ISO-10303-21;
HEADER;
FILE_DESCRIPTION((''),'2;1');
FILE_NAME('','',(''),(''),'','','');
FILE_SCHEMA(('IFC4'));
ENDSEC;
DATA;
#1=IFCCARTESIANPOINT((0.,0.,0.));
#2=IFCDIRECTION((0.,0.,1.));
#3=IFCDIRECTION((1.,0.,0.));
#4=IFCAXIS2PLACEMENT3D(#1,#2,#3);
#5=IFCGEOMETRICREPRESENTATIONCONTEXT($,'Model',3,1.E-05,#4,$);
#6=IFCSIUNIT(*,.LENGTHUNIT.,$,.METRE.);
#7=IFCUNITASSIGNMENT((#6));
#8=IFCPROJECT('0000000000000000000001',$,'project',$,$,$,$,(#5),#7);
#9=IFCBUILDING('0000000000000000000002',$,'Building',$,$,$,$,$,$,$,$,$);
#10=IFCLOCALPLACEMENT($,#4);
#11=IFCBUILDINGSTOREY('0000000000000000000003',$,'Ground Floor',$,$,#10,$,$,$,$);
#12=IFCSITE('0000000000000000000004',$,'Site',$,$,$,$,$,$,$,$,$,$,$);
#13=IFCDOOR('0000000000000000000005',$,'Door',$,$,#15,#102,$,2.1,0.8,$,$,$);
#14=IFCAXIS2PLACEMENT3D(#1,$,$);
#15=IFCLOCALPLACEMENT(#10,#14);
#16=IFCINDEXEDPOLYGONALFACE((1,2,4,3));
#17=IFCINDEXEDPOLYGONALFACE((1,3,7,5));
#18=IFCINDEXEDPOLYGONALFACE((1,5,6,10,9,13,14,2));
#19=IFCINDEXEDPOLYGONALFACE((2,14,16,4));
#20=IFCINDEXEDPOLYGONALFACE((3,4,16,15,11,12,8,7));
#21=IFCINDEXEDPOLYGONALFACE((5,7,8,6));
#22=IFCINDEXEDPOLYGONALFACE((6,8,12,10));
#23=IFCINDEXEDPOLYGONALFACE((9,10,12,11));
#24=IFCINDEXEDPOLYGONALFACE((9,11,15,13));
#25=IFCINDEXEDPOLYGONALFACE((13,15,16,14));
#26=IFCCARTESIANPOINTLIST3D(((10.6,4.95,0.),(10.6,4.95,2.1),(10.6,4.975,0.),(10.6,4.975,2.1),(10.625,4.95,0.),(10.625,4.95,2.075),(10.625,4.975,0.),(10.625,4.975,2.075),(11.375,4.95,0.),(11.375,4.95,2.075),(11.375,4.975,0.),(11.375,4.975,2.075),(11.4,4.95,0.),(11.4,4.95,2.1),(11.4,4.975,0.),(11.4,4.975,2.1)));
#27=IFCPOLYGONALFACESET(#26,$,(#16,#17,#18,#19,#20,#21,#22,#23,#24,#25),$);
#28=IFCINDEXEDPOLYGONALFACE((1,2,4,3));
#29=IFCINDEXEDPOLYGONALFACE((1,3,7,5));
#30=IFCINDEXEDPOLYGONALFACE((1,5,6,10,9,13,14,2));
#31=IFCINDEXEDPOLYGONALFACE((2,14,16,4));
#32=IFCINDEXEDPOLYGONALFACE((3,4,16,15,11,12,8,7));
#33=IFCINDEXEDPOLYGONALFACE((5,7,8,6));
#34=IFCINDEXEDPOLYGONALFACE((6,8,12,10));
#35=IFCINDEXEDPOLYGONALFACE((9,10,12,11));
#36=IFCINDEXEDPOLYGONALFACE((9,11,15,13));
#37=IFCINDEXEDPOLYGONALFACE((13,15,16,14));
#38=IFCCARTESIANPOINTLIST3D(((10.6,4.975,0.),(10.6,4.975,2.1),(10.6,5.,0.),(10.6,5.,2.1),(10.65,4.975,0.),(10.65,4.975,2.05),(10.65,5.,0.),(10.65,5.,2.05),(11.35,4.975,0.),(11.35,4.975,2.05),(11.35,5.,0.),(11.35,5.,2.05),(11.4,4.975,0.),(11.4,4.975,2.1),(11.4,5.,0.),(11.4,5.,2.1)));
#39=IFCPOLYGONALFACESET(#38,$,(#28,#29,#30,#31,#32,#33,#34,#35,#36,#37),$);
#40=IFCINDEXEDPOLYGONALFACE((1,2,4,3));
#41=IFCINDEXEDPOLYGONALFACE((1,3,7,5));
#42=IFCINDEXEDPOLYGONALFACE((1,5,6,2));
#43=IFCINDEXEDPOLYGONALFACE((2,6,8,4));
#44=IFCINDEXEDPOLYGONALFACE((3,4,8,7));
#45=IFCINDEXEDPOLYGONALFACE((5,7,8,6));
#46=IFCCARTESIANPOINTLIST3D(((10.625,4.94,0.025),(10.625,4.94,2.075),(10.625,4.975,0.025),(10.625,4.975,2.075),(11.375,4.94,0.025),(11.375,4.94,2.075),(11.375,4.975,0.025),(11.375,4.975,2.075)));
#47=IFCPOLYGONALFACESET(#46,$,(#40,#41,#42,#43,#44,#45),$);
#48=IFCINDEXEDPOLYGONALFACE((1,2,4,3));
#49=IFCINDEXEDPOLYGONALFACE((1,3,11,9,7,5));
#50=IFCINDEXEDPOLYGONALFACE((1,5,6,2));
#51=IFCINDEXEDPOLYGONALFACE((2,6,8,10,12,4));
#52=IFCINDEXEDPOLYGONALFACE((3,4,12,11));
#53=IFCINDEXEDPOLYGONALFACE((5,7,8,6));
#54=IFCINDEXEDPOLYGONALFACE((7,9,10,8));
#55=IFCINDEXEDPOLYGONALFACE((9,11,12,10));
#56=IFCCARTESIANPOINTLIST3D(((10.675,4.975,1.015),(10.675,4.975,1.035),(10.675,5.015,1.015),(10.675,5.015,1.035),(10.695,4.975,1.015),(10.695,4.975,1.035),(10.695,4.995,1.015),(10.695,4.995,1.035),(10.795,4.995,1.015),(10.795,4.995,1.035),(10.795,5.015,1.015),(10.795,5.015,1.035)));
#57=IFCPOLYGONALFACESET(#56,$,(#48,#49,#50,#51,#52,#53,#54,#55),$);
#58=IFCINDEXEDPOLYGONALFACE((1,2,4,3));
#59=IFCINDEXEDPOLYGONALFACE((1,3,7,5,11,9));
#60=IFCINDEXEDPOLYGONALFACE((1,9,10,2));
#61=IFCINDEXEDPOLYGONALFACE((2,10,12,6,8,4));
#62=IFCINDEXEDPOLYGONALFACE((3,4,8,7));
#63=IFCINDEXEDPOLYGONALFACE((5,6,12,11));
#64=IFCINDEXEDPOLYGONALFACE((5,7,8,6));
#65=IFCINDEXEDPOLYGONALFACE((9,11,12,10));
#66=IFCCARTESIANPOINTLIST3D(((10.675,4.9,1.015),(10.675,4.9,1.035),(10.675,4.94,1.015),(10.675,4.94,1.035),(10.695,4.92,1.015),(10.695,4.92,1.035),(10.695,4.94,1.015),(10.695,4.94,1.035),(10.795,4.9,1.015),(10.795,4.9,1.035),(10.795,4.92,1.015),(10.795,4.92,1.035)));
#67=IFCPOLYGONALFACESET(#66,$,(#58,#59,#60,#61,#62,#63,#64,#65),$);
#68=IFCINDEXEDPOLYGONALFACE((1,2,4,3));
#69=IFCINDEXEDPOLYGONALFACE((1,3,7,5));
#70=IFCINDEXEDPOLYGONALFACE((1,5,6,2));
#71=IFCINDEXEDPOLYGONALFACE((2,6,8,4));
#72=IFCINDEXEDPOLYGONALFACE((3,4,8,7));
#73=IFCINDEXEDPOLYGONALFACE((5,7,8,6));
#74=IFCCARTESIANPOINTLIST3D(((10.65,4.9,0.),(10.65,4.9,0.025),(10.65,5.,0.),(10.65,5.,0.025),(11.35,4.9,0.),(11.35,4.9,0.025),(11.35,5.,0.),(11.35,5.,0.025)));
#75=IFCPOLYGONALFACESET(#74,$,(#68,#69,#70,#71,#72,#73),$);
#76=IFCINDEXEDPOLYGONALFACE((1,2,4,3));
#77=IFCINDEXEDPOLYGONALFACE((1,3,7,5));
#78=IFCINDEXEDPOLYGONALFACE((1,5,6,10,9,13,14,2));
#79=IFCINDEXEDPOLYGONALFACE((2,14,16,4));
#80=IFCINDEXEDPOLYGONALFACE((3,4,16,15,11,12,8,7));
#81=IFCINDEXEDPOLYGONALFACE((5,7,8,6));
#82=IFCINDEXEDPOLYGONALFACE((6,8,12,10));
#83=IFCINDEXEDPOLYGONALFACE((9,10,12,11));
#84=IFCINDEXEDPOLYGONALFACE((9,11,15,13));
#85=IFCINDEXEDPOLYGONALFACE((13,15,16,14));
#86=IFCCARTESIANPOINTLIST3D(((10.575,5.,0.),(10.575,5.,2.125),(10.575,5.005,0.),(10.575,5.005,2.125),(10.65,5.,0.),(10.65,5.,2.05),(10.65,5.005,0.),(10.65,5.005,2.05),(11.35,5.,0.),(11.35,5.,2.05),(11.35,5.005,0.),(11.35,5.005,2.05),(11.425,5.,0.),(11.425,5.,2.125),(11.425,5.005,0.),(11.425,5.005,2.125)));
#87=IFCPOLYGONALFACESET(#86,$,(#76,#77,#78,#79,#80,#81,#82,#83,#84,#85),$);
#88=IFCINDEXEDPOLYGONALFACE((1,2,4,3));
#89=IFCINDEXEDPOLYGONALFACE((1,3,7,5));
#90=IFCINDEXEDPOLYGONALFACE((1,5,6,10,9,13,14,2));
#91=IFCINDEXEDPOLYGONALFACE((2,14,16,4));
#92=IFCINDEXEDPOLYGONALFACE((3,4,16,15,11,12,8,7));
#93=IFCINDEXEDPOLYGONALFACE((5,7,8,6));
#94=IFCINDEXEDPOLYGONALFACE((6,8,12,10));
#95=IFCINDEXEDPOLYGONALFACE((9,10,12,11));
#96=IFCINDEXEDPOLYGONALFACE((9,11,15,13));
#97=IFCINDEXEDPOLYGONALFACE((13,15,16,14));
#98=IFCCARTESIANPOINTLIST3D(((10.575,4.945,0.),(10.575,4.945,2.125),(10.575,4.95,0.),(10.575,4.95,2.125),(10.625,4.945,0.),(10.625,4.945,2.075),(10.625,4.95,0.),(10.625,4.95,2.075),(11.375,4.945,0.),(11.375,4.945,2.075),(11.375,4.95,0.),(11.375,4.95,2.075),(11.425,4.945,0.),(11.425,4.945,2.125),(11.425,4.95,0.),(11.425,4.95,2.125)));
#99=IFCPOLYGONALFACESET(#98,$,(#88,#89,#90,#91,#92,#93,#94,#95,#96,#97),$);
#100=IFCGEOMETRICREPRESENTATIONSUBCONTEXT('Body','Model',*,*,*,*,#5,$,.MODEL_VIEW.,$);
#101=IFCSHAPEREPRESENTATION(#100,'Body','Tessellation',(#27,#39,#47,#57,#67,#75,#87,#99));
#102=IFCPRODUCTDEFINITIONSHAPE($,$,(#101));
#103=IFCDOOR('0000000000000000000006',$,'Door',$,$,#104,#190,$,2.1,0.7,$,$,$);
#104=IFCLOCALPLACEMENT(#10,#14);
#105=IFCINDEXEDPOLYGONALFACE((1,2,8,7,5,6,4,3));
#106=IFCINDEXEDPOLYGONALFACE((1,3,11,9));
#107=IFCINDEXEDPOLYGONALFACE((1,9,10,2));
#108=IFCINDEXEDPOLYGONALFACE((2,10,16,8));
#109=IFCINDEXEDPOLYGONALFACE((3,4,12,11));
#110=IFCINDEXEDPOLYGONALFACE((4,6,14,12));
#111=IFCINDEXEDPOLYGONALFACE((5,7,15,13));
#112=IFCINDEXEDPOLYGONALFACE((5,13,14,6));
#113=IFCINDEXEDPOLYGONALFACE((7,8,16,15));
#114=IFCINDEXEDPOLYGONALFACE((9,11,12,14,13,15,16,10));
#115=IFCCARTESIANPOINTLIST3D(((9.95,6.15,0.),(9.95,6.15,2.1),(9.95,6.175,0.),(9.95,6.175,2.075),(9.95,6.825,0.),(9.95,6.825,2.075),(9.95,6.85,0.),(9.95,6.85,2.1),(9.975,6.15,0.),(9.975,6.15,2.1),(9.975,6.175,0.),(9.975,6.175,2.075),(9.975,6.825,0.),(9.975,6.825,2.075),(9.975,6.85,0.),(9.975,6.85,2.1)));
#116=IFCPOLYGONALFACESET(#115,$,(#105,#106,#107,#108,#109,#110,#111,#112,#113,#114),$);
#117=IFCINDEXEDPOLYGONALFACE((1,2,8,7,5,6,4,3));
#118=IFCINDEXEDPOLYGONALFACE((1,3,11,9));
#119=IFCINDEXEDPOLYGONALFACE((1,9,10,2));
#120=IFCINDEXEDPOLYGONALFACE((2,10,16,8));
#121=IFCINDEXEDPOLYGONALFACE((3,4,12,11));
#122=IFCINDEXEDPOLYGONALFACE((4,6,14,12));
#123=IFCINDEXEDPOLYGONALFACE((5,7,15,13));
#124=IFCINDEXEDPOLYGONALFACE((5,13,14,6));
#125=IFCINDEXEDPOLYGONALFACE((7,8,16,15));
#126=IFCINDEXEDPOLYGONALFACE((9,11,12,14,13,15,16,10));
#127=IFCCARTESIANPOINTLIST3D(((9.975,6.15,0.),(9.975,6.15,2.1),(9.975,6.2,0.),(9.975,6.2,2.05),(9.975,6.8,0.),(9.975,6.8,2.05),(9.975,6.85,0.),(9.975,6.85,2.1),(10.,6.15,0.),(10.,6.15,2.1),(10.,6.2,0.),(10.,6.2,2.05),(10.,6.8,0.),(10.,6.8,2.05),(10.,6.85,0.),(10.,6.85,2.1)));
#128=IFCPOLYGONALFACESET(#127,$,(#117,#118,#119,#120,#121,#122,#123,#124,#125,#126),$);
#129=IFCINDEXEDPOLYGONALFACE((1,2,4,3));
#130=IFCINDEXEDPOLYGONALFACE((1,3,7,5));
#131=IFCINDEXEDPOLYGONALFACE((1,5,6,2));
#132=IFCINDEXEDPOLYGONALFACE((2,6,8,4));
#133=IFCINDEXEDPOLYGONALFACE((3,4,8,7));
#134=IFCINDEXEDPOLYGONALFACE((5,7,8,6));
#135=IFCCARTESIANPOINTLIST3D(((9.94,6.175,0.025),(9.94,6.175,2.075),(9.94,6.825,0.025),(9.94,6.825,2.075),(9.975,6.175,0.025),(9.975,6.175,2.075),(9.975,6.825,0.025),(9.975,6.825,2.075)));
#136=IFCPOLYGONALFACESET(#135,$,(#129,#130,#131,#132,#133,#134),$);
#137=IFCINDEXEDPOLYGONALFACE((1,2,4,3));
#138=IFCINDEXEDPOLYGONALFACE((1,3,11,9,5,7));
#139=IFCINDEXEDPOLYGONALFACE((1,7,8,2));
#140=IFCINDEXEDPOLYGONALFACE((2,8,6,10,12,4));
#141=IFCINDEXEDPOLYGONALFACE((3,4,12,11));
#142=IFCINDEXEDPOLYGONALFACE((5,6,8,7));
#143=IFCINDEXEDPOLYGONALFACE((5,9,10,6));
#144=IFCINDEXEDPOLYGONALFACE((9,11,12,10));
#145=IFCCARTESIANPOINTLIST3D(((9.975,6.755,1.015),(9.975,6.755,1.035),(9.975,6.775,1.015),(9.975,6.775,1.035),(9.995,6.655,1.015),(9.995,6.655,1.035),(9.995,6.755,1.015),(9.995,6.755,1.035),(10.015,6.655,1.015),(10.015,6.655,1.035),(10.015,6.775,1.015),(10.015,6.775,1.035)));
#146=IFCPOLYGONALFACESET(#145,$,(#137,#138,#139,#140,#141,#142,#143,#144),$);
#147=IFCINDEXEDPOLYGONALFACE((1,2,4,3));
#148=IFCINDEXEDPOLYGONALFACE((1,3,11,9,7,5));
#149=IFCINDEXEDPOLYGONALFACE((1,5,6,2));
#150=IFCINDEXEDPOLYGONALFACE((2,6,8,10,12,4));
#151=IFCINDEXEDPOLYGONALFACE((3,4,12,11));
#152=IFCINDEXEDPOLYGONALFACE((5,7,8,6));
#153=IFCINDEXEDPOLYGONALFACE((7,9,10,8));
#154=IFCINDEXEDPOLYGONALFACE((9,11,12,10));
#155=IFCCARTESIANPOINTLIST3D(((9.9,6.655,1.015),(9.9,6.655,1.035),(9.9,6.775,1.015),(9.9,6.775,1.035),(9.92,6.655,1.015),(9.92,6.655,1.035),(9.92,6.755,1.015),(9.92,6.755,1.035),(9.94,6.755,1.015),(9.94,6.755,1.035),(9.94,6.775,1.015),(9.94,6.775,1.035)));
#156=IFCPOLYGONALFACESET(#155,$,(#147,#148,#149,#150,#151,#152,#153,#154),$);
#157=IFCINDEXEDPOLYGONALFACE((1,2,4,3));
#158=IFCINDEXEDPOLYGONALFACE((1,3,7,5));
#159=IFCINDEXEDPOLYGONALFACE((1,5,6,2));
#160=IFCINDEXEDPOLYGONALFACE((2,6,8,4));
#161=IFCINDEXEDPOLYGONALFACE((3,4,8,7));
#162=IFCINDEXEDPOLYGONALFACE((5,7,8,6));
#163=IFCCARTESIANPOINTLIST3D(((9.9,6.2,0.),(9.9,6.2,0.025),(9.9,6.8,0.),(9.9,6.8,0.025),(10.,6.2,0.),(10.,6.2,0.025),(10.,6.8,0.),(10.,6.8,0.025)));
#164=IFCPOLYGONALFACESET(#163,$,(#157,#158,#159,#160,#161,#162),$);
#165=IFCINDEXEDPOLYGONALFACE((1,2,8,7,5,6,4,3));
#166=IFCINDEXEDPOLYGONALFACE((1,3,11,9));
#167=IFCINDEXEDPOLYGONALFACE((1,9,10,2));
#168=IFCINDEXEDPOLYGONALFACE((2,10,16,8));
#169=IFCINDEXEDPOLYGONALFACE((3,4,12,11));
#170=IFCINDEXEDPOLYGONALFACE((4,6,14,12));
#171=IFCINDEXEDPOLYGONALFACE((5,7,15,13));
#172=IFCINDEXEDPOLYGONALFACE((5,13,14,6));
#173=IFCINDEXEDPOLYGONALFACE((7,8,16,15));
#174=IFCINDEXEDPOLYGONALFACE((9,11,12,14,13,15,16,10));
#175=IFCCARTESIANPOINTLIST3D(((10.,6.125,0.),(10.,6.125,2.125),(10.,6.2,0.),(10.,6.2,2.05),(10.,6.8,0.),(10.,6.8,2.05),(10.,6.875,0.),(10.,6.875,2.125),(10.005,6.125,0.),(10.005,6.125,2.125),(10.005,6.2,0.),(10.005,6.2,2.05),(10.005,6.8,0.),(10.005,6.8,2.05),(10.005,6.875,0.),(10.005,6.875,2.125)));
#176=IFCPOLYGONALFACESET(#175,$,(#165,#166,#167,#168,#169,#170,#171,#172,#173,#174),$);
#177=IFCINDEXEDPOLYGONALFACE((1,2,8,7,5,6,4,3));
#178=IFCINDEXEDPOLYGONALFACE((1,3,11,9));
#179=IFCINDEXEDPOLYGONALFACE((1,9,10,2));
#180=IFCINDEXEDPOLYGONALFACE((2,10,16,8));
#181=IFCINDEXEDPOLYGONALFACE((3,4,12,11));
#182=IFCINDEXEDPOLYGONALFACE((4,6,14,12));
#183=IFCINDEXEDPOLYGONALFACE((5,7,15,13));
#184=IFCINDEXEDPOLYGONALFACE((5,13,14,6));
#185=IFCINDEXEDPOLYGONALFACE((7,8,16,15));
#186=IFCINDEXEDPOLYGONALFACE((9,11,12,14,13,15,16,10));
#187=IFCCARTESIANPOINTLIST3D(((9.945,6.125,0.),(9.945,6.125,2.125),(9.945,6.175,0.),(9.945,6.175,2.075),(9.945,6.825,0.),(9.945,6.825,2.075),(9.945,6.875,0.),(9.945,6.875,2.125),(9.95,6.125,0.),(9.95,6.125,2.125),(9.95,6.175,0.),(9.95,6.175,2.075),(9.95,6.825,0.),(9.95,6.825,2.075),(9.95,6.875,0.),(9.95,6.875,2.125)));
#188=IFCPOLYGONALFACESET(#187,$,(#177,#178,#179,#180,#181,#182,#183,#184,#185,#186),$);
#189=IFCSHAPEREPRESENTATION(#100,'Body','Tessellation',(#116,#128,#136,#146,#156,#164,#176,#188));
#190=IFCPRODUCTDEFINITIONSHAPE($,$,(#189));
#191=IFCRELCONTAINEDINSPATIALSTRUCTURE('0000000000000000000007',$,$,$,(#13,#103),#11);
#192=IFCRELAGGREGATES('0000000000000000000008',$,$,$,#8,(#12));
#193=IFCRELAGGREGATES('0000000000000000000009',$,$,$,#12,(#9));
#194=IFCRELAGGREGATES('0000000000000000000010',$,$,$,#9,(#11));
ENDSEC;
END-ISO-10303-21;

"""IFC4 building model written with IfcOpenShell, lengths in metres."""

from ifc_helpers import new_model, si_unit, frame, origin_with_axes, place, context, subcontext, project, spatial, line, indexed_curve, outline, extrude, element, save


model = new_model("IFC4")

# Units and contexts
model_context = context("Model", 3, precision=1e-05, world=origin_with_axes())
body_context = subcontext(model_context, "Body", "Model", "MODEL_VIEW")
ifc_project = project(units=[si_unit("LENGTHUNIT", "METRE")], contexts=[model_context])

# Site, building, storey
site = spatial("IfcSite", under=ifc_project, Name="Site")
building = spatial("IfcBuilding", under=site, Name="Building")
storey_placement = place(None, origin_with_axes())
storey = spatial("IfcBuildingStorey", under=building, at=storey_placement, Name="Ground Floor")

# Doors
door_1_placement = place(storey_placement, frame((11.4, 5.0, 0.0), z_axis=(0.0, 0.0, 1.0), x_axis=(-1.0, 0.0, 0.0)))
element("IfcDoor", 1, at=door_1_placement, inside=storey, Name="Door", OverallHeight=2.1, OverallWidth=0.8, context=body_context, shape_type="SweptSolid", body=[
    extrude(outline(indexed_curve([(0.0, 0.0), (0.0, 2.1), (0.8, 2.1), (0.8, 0.0), (0.775, 0.0), (0.775, 2.075), (0.025, 2.075), (0.025, 0.0)], segments=[line(1, 2, 3, 4, 5, 6, 7, 8, 1)])), frame((0.0, 0.025, 0.0), z_axis=(0.0, -1.0, 0.0), x_axis=(1.0, 0.0, 0.0)), (0.0, 0.0, -1.0), 0.025),
    extrude(outline(indexed_curve([(0.0, 0.0), (0.0, 2.1), (0.8, 2.1), (0.8, 0.0), (0.75, 0.0), (0.75, 2.05), (0.05, 2.05), (0.05, 0.0)], segments=[line(1, 2, 3, 4, 5, 6, 7, 8, 1)])), frame((0.0, 0.0, 0.0), z_axis=(0.0, -1.0, 0.0), x_axis=(1.0, 0.0, 0.0)), (0.0, 0.0, -1.0), 0.025),
    extrude(outline(indexed_curve([(0.0, 0.0), (0.75, 0.0), (0.75, 0.035), (0.0, 0.035)], segments=[line(1, 2, 3, 4, 1)])), frame((0.025, 0.025, 0.025), z_axis=(0.0, 0.0, 1.0), x_axis=(1.0, 0.0, 0.0)), (0.0, 0.0, 1.0), 2.05),
    extrude(outline(indexed_curve([(0.0, 0.0), (0.0, -0.04), (-0.12, -0.04), (-0.12, -0.02), (-0.02, -0.02), (-0.02, 0.0)], segments=[line(1, 2, 3, 4, 5, 6, 1)])), frame((0.725, 0.025, 1.015), z_axis=(0.0, 0.0, 1.0), x_axis=(1.0, 0.0, 0.0)), (0.0, 0.0, 1.0), 0.02),
    extrude(outline(indexed_curve([(0.0, 0.0), (0.0, 0.04), (-0.12, 0.04), (-0.12, 0.02), (-0.02, 0.02), (-0.02, 0.0)], segments=[line(1, 2, 3, 4, 5, 6, 1)])), frame((0.725, 0.06, 1.015), z_axis=(0.0, 0.0, 1.0), x_axis=(1.0, 0.0, 0.0)), (0.0, 0.0, 1.0), 0.02),
    extrude(outline(indexed_curve([(0.0, 0.0), (0.7, 0.0), (0.7, 0.1), (0.0, 0.1)], segments=[line(1, 2, 3, 4, 1)])), frame((0.05, 0.0, 0.0), z_axis=(0.0, 0.0, 1.0), x_axis=(1.0, 0.0, 0.0)), (0.0, 0.0, 1.0), 0.025),
    extrude(outline(indexed_curve([(0.0, 0.0), (0.0, 2.125), (0.85, 2.125), (0.85, 0.0), (0.775, 0.0), (0.775, 2.05), (0.075, 2.05), (0.075, 0.0)], segments=[line(1, 2, 3, 4, 5, 6, 7, 8, 1)])), frame((-0.025, -0.005, 0.0), z_axis=(0.0, -1.0, 0.0), x_axis=(1.0, 0.0, 0.0)), (0.0, 0.0, -1.0), 0.005),
    extrude(outline(indexed_curve([(0.0, 0.0), (0.0, 2.125), (0.85, 2.125), (0.85, 0.0), (0.8, 0.0), (0.8, 2.075), (0.05, 2.075), (0.05, 0.0)], segments=[line(1, 2, 3, 4, 5, 6, 7, 8, 1)])), frame((-0.025, 0.05, 0.0), z_axis=(0.0, -1.0, 0.0), x_axis=(1.0, 0.0, 0.0)), (0.0, 0.0, -1.0), 0.005),
])
door_2_placement = place(storey_placement, frame((10.0, 6.15, 0.0), z_axis=(0.0, 0.0, 1.0), x_axis=(0.0, 1.0, 0.0)))
element("IfcDoor", 2, at=door_2_placement, inside=storey, Name="Door", OverallHeight=2.1, OverallWidth=0.7, context=body_context, shape_type="SweptSolid", body=[
    extrude(outline(indexed_curve([(0.0, 0.0), (0.0, 2.1), (0.7, 2.1), (0.7, 0.0), (0.675, 0.0), (0.675, 2.075), (0.025, 2.075), (0.025, 0.0)], segments=[line(1, 2, 3, 4, 5, 6, 7, 8, 1)])), frame((0.0, 0.025, 0.0), z_axis=(0.0, -1.0, 0.0), x_axis=(1.0, 0.0, 0.0)), (0.0, 0.0, -1.0), 0.025),
    extrude(outline(indexed_curve([(0.0, 0.0), (0.0, 2.1), (0.7, 2.1), (0.7, 0.0), (0.65, 0.0), (0.65, 2.05), (0.05, 2.05), (0.05, 0.0)], segments=[line(1, 2, 3, 4, 5, 6, 7, 8, 1)])), frame((0.0, 0.0, 0.0), z_axis=(0.0, -1.0, 0.0), x_axis=(1.0, 0.0, 0.0)), (0.0, 0.0, -1.0), 0.025),
    extrude(outline(indexed_curve([(0.0, 0.0), (0.65, 0.0), (0.65, 0.035), (0.0, 0.035)], segments=[line(1, 2, 3, 4, 1)])), frame((0.025, 0.025, 0.025), z_axis=(0.0, 0.0, 1.0), x_axis=(1.0, 0.0, 0.0)), (0.0, 0.0, 1.0), 2.05),
    extrude(outline(indexed_curve([(0.0, 0.0), (0.0, -0.04), (-0.12, -0.04), (-0.12, -0.02), (-0.02, -0.02), (-0.02, 0.0)], segments=[line(1, 2, 3, 4, 5, 6, 1)])), frame((0.625, 0.025, 1.015), z_axis=(0.0, 0.0, 1.0), x_axis=(1.0, 0.0, 0.0)), (0.0, 0.0, 1.0), 0.02),
    extrude(outline(indexed_curve([(0.0, 0.0), (0.0, 0.04), (-0.12, 0.04), (-0.12, 0.02), (-0.02, 0.02), (-0.02, 0.0)], segments=[line(1, 2, 3, 4, 5, 6, 1)])), frame((0.625, 0.06, 1.015), z_axis=(0.0, 0.0, 1.0), x_axis=(1.0, 0.0, 0.0)), (0.0, 0.0, 1.0), 0.02),
    extrude(outline(indexed_curve([(0.0, 0.0), (0.6, 0.0), (0.6, 0.1), (0.0, 0.1)], segments=[line(1, 2, 3, 4, 1)])), frame((0.05, 0.0, 0.0), z_axis=(0.0, 0.0, 1.0), x_axis=(1.0, 0.0, 0.0)), (0.0, 0.0, 1.0), 0.025),
    extrude(outline(indexed_curve([(0.0, 0.0), (0.0, 2.125), (0.75, 2.125), (0.75, 0.0), (0.675, 0.0), (0.675, 2.05), (0.075, 2.05), (0.075, 0.0)], segments=[line(1, 2, 3, 4, 5, 6, 7, 8, 1)])), frame((-0.025, -0.005, 0.0), z_axis=(0.0, -1.0, 0.0), x_axis=(1.0, 0.0, 0.0)), (0.0, 0.0, -1.0), 0.005),
    extrude(outline(indexed_curve([(0.0, 0.0), (0.0, 2.125), (0.75, 2.125), (0.75, 0.0), (0.7, 0.0), (0.7, 2.075), (0.05, 2.075), (0.05, 0.0)], segments=[line(1, 2, 3, 4, 5, 6, 7, 8, 1)])), frame((-0.025, 0.05, 0.0), z_axis=(0.0, -1.0, 0.0), x_axis=(1.0, 0.0, 0.0)), (0.0, 0.0, -1.0), 0.005),
])

save(model, "model.ifc")
